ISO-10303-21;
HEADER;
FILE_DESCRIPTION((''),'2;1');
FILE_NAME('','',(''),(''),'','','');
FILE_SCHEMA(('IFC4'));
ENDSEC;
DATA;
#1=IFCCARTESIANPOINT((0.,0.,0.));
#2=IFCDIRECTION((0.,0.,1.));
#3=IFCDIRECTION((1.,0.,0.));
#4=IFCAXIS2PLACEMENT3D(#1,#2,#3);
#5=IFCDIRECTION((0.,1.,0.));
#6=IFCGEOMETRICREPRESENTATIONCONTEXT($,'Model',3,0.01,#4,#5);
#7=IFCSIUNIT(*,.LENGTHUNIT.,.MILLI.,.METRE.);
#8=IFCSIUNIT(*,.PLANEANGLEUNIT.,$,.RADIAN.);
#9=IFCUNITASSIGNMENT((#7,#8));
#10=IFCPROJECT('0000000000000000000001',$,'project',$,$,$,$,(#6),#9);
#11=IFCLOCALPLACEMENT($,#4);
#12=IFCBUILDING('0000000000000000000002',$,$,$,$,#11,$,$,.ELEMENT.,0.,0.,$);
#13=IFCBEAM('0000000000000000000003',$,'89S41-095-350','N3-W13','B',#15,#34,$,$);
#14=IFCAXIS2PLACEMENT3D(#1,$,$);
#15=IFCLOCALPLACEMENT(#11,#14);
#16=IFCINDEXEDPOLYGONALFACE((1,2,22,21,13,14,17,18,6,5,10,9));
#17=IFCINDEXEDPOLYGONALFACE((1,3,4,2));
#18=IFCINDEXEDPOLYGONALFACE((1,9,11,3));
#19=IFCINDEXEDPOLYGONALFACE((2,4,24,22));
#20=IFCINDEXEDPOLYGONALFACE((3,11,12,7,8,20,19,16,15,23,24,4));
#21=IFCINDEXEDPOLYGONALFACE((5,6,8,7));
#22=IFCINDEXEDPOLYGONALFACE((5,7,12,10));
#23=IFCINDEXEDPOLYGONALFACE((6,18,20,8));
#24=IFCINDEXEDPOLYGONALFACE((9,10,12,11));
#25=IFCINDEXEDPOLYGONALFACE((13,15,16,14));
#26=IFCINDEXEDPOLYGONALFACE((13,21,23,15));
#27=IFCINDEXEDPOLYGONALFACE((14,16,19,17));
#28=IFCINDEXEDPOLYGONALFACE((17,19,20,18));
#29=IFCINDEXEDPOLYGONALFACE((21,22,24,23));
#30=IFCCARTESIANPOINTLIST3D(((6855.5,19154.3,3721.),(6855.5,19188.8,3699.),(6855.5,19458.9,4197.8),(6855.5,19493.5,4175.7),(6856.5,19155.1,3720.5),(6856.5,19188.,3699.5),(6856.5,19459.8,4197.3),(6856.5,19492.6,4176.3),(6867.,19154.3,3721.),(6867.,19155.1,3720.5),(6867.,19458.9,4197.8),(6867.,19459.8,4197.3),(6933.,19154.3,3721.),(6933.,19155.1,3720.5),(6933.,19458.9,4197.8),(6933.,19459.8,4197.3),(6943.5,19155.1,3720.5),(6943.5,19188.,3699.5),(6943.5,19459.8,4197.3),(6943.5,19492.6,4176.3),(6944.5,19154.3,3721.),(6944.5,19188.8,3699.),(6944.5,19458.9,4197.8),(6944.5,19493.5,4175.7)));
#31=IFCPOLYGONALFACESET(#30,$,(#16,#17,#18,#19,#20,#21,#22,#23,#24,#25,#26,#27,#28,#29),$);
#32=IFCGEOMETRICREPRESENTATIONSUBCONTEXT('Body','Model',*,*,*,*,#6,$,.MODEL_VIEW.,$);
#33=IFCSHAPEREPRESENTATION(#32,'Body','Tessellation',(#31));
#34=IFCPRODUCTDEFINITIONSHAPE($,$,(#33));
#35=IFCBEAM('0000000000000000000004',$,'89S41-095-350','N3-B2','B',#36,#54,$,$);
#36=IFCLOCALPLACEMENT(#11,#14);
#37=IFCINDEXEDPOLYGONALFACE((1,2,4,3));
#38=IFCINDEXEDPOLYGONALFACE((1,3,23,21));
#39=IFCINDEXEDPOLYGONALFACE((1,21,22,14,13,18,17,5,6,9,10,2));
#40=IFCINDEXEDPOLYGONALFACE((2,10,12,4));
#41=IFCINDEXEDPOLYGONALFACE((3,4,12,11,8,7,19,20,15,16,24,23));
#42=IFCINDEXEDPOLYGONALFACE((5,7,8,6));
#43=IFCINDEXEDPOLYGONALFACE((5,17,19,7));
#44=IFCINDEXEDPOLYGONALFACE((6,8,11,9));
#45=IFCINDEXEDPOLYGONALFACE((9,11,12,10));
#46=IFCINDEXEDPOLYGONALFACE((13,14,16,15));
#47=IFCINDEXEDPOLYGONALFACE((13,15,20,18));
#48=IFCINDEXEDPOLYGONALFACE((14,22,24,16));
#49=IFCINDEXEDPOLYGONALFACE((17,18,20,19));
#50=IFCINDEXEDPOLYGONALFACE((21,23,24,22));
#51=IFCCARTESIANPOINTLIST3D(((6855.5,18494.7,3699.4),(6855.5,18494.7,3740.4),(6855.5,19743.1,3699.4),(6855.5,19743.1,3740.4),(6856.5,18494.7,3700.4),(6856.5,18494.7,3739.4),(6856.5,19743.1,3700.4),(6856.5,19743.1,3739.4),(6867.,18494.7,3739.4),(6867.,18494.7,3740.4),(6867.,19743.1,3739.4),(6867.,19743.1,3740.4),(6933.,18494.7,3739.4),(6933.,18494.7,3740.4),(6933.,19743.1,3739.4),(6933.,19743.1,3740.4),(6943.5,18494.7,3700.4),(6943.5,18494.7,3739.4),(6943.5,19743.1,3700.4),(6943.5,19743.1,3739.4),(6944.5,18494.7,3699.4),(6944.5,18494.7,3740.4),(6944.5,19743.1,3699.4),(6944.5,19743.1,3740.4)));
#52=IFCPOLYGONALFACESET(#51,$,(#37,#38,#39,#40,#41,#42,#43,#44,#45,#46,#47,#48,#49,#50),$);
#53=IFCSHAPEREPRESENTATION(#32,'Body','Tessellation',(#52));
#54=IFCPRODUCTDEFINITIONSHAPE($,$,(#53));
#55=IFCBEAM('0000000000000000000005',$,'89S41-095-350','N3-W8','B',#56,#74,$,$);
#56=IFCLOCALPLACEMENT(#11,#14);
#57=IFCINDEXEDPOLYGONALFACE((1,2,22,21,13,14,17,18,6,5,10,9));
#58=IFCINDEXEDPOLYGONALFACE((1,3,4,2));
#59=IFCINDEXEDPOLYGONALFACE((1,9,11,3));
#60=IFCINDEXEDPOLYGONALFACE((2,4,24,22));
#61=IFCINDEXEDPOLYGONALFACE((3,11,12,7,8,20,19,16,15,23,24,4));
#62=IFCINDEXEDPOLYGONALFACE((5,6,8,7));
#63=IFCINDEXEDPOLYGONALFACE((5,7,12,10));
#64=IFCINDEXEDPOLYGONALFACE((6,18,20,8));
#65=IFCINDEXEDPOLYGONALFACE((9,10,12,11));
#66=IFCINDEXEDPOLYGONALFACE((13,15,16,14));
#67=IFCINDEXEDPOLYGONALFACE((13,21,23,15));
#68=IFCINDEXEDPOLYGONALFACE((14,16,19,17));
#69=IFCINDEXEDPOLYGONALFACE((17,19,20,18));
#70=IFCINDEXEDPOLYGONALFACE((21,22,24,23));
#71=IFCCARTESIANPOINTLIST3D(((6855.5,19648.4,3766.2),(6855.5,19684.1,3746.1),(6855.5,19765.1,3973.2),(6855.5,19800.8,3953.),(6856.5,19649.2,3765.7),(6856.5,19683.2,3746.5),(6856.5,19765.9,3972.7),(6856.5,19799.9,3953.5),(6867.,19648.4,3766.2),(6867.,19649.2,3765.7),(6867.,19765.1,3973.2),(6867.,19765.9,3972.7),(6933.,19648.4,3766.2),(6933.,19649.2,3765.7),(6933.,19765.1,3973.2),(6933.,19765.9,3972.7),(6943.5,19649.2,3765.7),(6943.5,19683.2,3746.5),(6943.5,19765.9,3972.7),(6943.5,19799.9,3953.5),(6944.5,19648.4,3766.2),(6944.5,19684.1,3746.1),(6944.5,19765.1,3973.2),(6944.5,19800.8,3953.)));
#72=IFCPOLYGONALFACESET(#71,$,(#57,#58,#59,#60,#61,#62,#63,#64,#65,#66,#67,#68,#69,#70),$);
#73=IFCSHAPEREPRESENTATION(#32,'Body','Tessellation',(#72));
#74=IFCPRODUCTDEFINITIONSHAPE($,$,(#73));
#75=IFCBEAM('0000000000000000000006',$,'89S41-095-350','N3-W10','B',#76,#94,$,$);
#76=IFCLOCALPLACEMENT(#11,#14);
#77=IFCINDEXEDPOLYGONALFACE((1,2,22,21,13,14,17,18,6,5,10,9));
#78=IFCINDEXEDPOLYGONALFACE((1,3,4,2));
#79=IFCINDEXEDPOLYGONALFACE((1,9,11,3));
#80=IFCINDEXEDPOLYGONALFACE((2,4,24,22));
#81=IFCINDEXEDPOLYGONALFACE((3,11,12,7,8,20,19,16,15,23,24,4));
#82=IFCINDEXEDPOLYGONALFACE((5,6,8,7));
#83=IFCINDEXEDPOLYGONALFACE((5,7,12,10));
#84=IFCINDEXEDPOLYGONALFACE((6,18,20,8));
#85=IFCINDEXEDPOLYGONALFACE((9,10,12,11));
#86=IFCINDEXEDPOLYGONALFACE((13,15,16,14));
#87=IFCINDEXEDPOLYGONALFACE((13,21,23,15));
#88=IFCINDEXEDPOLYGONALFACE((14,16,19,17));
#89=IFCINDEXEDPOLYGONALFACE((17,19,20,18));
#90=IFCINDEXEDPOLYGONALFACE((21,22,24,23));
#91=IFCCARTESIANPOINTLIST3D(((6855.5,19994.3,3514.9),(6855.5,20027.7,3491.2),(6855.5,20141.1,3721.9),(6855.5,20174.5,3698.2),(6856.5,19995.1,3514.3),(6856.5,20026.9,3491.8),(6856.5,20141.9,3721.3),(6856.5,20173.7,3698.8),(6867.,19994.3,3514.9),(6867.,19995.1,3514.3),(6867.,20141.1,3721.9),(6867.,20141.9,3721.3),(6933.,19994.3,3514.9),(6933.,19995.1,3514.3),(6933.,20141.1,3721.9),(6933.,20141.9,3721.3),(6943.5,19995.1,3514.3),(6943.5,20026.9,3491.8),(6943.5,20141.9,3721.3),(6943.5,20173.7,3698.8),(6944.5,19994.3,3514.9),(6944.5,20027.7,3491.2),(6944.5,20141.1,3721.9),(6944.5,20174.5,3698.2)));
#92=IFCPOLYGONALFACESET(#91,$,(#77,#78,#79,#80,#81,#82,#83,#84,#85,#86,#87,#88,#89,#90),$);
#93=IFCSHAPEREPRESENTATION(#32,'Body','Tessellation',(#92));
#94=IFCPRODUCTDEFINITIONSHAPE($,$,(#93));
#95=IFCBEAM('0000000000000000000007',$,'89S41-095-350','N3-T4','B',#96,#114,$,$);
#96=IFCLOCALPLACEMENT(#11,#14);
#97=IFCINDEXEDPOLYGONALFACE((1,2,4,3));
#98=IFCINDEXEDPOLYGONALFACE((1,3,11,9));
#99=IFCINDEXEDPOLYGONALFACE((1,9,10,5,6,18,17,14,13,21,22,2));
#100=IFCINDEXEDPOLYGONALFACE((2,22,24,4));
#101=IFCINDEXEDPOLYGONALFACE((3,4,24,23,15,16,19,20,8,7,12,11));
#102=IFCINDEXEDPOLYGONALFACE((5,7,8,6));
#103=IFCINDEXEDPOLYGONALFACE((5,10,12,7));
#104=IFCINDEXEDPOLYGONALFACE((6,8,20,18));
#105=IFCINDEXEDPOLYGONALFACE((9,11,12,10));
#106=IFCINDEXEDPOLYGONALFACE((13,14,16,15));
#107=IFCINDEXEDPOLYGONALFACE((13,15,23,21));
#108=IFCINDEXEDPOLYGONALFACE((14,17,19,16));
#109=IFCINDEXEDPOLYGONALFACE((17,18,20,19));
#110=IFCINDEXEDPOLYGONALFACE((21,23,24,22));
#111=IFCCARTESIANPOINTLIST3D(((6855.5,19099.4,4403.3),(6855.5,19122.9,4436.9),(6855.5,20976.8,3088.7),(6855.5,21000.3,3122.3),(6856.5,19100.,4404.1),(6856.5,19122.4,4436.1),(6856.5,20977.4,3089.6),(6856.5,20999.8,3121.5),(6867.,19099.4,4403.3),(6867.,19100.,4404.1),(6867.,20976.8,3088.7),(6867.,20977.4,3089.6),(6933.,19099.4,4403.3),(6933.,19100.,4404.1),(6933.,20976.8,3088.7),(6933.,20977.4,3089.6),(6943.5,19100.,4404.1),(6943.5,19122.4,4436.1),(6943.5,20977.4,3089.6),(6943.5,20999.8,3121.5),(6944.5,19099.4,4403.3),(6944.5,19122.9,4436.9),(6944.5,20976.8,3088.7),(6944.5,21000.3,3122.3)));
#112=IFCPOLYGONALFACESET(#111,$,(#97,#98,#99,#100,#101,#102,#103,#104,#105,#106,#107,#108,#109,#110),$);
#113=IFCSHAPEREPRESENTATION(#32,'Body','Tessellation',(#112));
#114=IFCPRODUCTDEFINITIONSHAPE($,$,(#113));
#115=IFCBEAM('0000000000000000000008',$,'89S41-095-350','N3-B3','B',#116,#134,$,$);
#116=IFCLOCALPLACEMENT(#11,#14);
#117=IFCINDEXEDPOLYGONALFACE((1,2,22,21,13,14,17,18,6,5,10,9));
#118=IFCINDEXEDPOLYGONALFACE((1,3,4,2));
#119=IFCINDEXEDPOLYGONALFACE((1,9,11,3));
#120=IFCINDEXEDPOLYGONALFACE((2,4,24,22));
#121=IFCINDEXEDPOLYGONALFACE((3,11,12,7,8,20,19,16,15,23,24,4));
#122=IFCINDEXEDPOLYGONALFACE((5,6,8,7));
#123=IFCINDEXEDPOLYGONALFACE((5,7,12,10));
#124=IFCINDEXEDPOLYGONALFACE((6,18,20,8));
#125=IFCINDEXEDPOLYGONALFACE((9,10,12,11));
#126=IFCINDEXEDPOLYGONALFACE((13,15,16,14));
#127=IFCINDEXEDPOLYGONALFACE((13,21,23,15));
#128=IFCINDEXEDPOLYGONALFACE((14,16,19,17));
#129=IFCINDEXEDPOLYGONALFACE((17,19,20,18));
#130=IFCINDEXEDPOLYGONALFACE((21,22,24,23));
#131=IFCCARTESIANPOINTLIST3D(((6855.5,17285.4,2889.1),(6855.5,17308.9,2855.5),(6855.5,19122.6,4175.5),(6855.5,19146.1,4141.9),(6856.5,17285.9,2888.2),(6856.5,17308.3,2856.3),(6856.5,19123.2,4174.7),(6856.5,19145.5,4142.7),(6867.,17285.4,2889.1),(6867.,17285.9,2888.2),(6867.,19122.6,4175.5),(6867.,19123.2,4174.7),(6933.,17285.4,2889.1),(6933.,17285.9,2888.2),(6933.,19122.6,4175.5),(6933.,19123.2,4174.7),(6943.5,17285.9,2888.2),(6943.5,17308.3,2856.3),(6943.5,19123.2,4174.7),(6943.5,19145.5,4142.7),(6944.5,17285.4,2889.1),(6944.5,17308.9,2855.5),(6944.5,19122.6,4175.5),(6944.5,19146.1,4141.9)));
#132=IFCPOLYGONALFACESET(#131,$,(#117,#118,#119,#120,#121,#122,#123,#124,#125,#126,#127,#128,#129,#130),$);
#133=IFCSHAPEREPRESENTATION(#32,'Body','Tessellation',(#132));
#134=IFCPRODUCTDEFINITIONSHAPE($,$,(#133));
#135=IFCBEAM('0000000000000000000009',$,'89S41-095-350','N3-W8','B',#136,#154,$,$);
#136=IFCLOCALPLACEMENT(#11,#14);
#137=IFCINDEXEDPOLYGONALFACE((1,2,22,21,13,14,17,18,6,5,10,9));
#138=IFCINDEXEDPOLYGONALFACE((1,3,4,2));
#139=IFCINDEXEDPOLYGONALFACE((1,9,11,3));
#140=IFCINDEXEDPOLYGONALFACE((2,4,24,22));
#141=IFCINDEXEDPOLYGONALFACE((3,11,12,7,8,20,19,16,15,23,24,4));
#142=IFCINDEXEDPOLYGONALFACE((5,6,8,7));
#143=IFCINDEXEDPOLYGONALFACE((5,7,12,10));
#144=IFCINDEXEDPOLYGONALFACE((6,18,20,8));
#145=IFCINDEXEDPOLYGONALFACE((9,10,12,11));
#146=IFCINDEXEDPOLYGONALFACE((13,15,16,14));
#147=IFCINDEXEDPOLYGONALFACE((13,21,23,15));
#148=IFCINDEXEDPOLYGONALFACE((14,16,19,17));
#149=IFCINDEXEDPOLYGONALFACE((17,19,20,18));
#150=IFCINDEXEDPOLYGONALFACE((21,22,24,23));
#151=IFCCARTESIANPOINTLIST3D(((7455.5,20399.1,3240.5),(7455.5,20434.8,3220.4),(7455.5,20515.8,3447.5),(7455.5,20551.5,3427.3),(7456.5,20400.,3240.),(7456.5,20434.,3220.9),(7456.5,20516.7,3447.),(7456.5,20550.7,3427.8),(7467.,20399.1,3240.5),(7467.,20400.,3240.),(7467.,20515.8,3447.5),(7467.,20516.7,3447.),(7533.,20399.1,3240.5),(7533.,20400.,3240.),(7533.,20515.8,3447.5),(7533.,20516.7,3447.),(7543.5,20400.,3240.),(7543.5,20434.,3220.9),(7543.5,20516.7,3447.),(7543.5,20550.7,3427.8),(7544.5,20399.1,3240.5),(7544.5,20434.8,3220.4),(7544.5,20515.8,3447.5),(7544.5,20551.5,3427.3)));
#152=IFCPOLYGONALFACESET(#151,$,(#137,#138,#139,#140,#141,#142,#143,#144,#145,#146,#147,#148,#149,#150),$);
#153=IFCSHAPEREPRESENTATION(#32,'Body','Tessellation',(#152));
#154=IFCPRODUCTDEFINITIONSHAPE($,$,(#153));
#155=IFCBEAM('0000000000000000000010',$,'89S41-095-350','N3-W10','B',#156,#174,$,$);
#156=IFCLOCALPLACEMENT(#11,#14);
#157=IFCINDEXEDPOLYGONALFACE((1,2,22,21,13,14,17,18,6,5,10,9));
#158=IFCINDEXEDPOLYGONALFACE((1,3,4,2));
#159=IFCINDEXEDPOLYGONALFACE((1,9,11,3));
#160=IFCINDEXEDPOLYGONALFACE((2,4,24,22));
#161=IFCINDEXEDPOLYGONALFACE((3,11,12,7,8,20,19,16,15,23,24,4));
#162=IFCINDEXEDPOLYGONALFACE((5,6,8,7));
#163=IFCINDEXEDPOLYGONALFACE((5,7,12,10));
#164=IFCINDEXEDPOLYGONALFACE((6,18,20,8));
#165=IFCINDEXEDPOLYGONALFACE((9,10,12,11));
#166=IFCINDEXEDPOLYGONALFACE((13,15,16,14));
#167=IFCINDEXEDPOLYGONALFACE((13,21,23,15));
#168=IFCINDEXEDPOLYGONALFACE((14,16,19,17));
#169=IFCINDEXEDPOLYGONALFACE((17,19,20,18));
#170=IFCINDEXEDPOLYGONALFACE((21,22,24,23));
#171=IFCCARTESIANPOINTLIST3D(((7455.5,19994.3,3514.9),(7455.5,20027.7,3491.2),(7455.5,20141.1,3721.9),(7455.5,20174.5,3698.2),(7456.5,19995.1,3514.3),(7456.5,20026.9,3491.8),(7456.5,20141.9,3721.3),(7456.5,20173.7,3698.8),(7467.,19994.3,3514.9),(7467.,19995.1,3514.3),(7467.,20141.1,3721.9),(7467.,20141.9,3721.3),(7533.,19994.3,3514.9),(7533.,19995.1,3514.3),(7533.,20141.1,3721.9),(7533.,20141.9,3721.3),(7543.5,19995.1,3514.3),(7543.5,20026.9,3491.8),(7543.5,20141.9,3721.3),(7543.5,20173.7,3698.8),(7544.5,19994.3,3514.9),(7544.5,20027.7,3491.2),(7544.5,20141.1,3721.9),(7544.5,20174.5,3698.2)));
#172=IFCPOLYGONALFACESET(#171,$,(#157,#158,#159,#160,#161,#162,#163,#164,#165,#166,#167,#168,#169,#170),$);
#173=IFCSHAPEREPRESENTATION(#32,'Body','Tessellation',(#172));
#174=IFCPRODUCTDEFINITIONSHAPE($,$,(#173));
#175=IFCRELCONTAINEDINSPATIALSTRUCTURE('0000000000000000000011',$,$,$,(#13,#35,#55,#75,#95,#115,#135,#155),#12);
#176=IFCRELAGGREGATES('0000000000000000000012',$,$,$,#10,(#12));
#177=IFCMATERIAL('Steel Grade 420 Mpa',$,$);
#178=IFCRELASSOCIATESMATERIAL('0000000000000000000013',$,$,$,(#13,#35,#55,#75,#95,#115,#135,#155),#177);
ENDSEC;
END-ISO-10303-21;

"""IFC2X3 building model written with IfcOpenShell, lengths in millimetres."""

from ifc_helpers import new_model, si_unit, direction, frame, origin, origin_with_axes, origin_2d_with_axis, place, context, subcontext, project, spatial, c_section, extrude, source, transform, mapped, material, element, save


model = new_model("IFC2X3")

# Units and contexts
model_context = context("Model", 3, precision=0.01, world=origin_with_axes(), true_north=direction((0.0, 1.0, 0.0)))
body_context = subcontext(model_context, "Body", "Model", "MODEL_VIEW")
ifc_project = project(units=[si_unit("LENGTHUNIT", "METRE", prefix="MILLI"), si_unit("PLANEANGLEUNIT", "RADIAN")], contexts=[model_context])

# Building
building_placement = place(None, origin_with_axes())
building = spatial("IfcBuilding", under=ifc_project, at=building_placement, CompositionType="ELEMENT", ElevationOfRefHeight=0.0, ElevationOfTerrain=0.0)

# Shared definitions
ifc_material = material(Name="Steel Grade 420 Mpa")

# Beams
shared_shape_1 = source(origin(), body_context, "Body", "SweptSolid", [
    extrude(c_section(Depth=89.0, Width=41.0, WallThickness=1.0, Girth=11.5, at=origin_2d_with_axis()), origin_with_axes(), (0.0, 0.0, 1.0), 565.8),
])
beam_1_placement = place(None, frame((6900.0, 19476.2, 4186.8), z_axis=(0.0, -0.538498, -0.842627), x_axis=(0.0, -0.842627, 0.538498)))
element("IfcBeam", 1, at=beam_1_placement, inside=building, material=ifc_material, Name="89S41-095-350", Description="N3-W13", ObjectType="B", context=body_context, shape_type="MappedRepresentation", body=[
    mapped(shared_shape_1, transform((0.0, 0.0, 0.0), scale=1.0)),
])
shared_shape_2 = source(origin(), body_context, "Body", "SweptSolid", [
    extrude(c_section(Depth=89.0, Width=41.0, WallThickness=1.0, Girth=11.5, at=origin_2d_with_axis()), origin_with_axes(), (0.0, 0.0, 1.0), 1248.4),
])
beam_2_placement = place(None, frame((6900.0, 19743.1, 3719.9), z_axis=(0.0, -1.0, 0.0), x_axis=(0.0, 0.0, 1.0)))
element("IfcBeam", 2, at=beam_2_placement, inside=building, material=ifc_material, Name="89S41-095-350", Description="N3-B2", ObjectType="B", context=body_context, shape_type="MappedRepresentation", body=[
    mapped(shared_shape_2, transform((0.0, 0.0, 0.0), scale=1.0)),
])
shared_shape_3 = source(origin(), body_context, "Body", "SweptSolid", [
    extrude(c_section(Depth=89.0, Width=41.0, WallThickness=1.0, Girth=11.5, at=origin_2d_with_axis()), origin_with_axes(), (0.0, 0.0, 1.0), 237.6),
])
beam_3_placement = place(None, frame((6900.0, 19782.9, 3963.1), z_axis=(0.0, -0.491169, -0.871064), x_axis=(0.0, -0.871064, 0.491169)))
element("IfcBeam", 3, at=beam_3_placement, inside=building, material=ifc_material, Name="89S41-095-350", Description="N3-W8", ObjectType="B", context=body_context, shape_type="MappedRepresentation", body=[
    mapped(shared_shape_3, transform((0.0, 0.0, 0.0), scale=1.0)),
])
shared_shape_4 = source(origin(), body_context, "Body", "SweptSolid", [
    extrude(c_section(Depth=89.0, Width=41.0, WallThickness=1.0, Girth=11.5, at=origin_2d_with_axis()), origin_with_axes(), (0.0, 0.0, 1.0), 253.8),
])
beam_4_placement = place(None, frame((6900.0, 20157.8, 3710.0), z_axis=(0.0, -0.578484, -0.815694), x_axis=(0.0, -0.815694, 0.578484)))
element("IfcBeam", 4, at=beam_4_placement, inside=building, material=ifc_material, Name="89S41-095-350", Description="N3-W10", ObjectType="B", context=body_context, shape_type="MappedRepresentation", body=[
    mapped(shared_shape_4, transform((0.0, 0.0, 0.0), scale=1.0)),
])
shared_shape_5 = source(origin(), body_context, "Body", "SweptSolid", [
    extrude(c_section(Depth=89.0, Width=41.0, WallThickness=1.0, Girth=11.5, at=origin_2d_with_axis()), origin_with_axes(), (0.0, 0.0, 1.0), 2291.9),
])
beam_5_placement = place(None, frame((6900.0, 19111.2, 4420.1), z_axis=(0.0, 0.819152, -0.573576), x_axis=(0.0, -0.573576, -0.819152)))
element("IfcBeam", 5, at=beam_5_placement, inside=building, material=ifc_material, Name="89S41-095-350", Description="N3-T4", ObjectType="B", context=body_context, shape_type="MappedRepresentation", body=[
    mapped(shared_shape_5, transform((0.0, 0.0, 0.0), scale=1.0)),
])
shared_shape_6 = source(origin(), body_context, "Body", "SweptSolid", [
    extrude(c_section(Depth=89.0, Width=41.0, WallThickness=1.0, Girth=11.5, at=origin_2d_with_axis()), origin_with_axes(), (0.0, 0.0, 1.0), 2242.8),
])
beam_6_placement = place(None, frame((6900.0, 19134.3, 4158.7), z_axis=(0.0, -0.819152, -0.573576), x_axis=(0.0, -0.573576, 0.819152)))
element("IfcBeam", 6, at=beam_6_placement, inside=building, material=ifc_material, Name="89S41-095-350", Description="N3-B3", ObjectType="B", context=body_context, shape_type="MappedRepresentation", body=[
    mapped(shared_shape_6, transform((0.0, 0.0, 0.0), scale=1.0)),
])
shared_shape_7 = source(origin(), body_context, "Body", "SweptSolid", [
    extrude(c_section(Depth=89.0, Width=41.0, WallThickness=1.0, Girth=11.5, at=origin_2d_with_axis()), origin_with_axes(), (0.0, 0.0, 1.0), 237.6),
])
beam_7_placement = place(None, frame((7500.0, 20533.7, 3437.4), z_axis=(0.0, -0.491169, -0.871064), x_axis=(0.0, -0.871064, 0.491169)))
element("IfcBeam", 7, at=beam_7_placement, inside=building, material=ifc_material, Name="89S41-095-350", Description="N3-W8", ObjectType="B", context=body_context, shape_type="MappedRepresentation", body=[
    mapped(shared_shape_7, transform((0.0, 0.0, 0.0), scale=1.0)),
])
shared_shape_8 = source(origin(), body_context, "Body", "SweptSolid", [
    extrude(c_section(Depth=89.0, Width=41.0, WallThickness=1.0, Girth=11.5, at=origin_2d_with_axis()), origin_with_axes(), (0.0, 0.0, 1.0), 253.8),
])
beam_8_placement = place(None, frame((7500.0, 20157.8, 3710.0), z_axis=(0.0, -0.578484, -0.815694), x_axis=(0.0, -0.815694, 0.578484)))
element("IfcBeam", 8, at=beam_8_placement, inside=building, material=ifc_material, Name="89S41-095-350", Description="N3-W10", ObjectType="B", context=body_context, shape_type="MappedRepresentation", body=[
    mapped(shared_shape_8, transform((0.0, 0.0, 0.0), scale=1.0)),
])

save(model, "model.ifc")
